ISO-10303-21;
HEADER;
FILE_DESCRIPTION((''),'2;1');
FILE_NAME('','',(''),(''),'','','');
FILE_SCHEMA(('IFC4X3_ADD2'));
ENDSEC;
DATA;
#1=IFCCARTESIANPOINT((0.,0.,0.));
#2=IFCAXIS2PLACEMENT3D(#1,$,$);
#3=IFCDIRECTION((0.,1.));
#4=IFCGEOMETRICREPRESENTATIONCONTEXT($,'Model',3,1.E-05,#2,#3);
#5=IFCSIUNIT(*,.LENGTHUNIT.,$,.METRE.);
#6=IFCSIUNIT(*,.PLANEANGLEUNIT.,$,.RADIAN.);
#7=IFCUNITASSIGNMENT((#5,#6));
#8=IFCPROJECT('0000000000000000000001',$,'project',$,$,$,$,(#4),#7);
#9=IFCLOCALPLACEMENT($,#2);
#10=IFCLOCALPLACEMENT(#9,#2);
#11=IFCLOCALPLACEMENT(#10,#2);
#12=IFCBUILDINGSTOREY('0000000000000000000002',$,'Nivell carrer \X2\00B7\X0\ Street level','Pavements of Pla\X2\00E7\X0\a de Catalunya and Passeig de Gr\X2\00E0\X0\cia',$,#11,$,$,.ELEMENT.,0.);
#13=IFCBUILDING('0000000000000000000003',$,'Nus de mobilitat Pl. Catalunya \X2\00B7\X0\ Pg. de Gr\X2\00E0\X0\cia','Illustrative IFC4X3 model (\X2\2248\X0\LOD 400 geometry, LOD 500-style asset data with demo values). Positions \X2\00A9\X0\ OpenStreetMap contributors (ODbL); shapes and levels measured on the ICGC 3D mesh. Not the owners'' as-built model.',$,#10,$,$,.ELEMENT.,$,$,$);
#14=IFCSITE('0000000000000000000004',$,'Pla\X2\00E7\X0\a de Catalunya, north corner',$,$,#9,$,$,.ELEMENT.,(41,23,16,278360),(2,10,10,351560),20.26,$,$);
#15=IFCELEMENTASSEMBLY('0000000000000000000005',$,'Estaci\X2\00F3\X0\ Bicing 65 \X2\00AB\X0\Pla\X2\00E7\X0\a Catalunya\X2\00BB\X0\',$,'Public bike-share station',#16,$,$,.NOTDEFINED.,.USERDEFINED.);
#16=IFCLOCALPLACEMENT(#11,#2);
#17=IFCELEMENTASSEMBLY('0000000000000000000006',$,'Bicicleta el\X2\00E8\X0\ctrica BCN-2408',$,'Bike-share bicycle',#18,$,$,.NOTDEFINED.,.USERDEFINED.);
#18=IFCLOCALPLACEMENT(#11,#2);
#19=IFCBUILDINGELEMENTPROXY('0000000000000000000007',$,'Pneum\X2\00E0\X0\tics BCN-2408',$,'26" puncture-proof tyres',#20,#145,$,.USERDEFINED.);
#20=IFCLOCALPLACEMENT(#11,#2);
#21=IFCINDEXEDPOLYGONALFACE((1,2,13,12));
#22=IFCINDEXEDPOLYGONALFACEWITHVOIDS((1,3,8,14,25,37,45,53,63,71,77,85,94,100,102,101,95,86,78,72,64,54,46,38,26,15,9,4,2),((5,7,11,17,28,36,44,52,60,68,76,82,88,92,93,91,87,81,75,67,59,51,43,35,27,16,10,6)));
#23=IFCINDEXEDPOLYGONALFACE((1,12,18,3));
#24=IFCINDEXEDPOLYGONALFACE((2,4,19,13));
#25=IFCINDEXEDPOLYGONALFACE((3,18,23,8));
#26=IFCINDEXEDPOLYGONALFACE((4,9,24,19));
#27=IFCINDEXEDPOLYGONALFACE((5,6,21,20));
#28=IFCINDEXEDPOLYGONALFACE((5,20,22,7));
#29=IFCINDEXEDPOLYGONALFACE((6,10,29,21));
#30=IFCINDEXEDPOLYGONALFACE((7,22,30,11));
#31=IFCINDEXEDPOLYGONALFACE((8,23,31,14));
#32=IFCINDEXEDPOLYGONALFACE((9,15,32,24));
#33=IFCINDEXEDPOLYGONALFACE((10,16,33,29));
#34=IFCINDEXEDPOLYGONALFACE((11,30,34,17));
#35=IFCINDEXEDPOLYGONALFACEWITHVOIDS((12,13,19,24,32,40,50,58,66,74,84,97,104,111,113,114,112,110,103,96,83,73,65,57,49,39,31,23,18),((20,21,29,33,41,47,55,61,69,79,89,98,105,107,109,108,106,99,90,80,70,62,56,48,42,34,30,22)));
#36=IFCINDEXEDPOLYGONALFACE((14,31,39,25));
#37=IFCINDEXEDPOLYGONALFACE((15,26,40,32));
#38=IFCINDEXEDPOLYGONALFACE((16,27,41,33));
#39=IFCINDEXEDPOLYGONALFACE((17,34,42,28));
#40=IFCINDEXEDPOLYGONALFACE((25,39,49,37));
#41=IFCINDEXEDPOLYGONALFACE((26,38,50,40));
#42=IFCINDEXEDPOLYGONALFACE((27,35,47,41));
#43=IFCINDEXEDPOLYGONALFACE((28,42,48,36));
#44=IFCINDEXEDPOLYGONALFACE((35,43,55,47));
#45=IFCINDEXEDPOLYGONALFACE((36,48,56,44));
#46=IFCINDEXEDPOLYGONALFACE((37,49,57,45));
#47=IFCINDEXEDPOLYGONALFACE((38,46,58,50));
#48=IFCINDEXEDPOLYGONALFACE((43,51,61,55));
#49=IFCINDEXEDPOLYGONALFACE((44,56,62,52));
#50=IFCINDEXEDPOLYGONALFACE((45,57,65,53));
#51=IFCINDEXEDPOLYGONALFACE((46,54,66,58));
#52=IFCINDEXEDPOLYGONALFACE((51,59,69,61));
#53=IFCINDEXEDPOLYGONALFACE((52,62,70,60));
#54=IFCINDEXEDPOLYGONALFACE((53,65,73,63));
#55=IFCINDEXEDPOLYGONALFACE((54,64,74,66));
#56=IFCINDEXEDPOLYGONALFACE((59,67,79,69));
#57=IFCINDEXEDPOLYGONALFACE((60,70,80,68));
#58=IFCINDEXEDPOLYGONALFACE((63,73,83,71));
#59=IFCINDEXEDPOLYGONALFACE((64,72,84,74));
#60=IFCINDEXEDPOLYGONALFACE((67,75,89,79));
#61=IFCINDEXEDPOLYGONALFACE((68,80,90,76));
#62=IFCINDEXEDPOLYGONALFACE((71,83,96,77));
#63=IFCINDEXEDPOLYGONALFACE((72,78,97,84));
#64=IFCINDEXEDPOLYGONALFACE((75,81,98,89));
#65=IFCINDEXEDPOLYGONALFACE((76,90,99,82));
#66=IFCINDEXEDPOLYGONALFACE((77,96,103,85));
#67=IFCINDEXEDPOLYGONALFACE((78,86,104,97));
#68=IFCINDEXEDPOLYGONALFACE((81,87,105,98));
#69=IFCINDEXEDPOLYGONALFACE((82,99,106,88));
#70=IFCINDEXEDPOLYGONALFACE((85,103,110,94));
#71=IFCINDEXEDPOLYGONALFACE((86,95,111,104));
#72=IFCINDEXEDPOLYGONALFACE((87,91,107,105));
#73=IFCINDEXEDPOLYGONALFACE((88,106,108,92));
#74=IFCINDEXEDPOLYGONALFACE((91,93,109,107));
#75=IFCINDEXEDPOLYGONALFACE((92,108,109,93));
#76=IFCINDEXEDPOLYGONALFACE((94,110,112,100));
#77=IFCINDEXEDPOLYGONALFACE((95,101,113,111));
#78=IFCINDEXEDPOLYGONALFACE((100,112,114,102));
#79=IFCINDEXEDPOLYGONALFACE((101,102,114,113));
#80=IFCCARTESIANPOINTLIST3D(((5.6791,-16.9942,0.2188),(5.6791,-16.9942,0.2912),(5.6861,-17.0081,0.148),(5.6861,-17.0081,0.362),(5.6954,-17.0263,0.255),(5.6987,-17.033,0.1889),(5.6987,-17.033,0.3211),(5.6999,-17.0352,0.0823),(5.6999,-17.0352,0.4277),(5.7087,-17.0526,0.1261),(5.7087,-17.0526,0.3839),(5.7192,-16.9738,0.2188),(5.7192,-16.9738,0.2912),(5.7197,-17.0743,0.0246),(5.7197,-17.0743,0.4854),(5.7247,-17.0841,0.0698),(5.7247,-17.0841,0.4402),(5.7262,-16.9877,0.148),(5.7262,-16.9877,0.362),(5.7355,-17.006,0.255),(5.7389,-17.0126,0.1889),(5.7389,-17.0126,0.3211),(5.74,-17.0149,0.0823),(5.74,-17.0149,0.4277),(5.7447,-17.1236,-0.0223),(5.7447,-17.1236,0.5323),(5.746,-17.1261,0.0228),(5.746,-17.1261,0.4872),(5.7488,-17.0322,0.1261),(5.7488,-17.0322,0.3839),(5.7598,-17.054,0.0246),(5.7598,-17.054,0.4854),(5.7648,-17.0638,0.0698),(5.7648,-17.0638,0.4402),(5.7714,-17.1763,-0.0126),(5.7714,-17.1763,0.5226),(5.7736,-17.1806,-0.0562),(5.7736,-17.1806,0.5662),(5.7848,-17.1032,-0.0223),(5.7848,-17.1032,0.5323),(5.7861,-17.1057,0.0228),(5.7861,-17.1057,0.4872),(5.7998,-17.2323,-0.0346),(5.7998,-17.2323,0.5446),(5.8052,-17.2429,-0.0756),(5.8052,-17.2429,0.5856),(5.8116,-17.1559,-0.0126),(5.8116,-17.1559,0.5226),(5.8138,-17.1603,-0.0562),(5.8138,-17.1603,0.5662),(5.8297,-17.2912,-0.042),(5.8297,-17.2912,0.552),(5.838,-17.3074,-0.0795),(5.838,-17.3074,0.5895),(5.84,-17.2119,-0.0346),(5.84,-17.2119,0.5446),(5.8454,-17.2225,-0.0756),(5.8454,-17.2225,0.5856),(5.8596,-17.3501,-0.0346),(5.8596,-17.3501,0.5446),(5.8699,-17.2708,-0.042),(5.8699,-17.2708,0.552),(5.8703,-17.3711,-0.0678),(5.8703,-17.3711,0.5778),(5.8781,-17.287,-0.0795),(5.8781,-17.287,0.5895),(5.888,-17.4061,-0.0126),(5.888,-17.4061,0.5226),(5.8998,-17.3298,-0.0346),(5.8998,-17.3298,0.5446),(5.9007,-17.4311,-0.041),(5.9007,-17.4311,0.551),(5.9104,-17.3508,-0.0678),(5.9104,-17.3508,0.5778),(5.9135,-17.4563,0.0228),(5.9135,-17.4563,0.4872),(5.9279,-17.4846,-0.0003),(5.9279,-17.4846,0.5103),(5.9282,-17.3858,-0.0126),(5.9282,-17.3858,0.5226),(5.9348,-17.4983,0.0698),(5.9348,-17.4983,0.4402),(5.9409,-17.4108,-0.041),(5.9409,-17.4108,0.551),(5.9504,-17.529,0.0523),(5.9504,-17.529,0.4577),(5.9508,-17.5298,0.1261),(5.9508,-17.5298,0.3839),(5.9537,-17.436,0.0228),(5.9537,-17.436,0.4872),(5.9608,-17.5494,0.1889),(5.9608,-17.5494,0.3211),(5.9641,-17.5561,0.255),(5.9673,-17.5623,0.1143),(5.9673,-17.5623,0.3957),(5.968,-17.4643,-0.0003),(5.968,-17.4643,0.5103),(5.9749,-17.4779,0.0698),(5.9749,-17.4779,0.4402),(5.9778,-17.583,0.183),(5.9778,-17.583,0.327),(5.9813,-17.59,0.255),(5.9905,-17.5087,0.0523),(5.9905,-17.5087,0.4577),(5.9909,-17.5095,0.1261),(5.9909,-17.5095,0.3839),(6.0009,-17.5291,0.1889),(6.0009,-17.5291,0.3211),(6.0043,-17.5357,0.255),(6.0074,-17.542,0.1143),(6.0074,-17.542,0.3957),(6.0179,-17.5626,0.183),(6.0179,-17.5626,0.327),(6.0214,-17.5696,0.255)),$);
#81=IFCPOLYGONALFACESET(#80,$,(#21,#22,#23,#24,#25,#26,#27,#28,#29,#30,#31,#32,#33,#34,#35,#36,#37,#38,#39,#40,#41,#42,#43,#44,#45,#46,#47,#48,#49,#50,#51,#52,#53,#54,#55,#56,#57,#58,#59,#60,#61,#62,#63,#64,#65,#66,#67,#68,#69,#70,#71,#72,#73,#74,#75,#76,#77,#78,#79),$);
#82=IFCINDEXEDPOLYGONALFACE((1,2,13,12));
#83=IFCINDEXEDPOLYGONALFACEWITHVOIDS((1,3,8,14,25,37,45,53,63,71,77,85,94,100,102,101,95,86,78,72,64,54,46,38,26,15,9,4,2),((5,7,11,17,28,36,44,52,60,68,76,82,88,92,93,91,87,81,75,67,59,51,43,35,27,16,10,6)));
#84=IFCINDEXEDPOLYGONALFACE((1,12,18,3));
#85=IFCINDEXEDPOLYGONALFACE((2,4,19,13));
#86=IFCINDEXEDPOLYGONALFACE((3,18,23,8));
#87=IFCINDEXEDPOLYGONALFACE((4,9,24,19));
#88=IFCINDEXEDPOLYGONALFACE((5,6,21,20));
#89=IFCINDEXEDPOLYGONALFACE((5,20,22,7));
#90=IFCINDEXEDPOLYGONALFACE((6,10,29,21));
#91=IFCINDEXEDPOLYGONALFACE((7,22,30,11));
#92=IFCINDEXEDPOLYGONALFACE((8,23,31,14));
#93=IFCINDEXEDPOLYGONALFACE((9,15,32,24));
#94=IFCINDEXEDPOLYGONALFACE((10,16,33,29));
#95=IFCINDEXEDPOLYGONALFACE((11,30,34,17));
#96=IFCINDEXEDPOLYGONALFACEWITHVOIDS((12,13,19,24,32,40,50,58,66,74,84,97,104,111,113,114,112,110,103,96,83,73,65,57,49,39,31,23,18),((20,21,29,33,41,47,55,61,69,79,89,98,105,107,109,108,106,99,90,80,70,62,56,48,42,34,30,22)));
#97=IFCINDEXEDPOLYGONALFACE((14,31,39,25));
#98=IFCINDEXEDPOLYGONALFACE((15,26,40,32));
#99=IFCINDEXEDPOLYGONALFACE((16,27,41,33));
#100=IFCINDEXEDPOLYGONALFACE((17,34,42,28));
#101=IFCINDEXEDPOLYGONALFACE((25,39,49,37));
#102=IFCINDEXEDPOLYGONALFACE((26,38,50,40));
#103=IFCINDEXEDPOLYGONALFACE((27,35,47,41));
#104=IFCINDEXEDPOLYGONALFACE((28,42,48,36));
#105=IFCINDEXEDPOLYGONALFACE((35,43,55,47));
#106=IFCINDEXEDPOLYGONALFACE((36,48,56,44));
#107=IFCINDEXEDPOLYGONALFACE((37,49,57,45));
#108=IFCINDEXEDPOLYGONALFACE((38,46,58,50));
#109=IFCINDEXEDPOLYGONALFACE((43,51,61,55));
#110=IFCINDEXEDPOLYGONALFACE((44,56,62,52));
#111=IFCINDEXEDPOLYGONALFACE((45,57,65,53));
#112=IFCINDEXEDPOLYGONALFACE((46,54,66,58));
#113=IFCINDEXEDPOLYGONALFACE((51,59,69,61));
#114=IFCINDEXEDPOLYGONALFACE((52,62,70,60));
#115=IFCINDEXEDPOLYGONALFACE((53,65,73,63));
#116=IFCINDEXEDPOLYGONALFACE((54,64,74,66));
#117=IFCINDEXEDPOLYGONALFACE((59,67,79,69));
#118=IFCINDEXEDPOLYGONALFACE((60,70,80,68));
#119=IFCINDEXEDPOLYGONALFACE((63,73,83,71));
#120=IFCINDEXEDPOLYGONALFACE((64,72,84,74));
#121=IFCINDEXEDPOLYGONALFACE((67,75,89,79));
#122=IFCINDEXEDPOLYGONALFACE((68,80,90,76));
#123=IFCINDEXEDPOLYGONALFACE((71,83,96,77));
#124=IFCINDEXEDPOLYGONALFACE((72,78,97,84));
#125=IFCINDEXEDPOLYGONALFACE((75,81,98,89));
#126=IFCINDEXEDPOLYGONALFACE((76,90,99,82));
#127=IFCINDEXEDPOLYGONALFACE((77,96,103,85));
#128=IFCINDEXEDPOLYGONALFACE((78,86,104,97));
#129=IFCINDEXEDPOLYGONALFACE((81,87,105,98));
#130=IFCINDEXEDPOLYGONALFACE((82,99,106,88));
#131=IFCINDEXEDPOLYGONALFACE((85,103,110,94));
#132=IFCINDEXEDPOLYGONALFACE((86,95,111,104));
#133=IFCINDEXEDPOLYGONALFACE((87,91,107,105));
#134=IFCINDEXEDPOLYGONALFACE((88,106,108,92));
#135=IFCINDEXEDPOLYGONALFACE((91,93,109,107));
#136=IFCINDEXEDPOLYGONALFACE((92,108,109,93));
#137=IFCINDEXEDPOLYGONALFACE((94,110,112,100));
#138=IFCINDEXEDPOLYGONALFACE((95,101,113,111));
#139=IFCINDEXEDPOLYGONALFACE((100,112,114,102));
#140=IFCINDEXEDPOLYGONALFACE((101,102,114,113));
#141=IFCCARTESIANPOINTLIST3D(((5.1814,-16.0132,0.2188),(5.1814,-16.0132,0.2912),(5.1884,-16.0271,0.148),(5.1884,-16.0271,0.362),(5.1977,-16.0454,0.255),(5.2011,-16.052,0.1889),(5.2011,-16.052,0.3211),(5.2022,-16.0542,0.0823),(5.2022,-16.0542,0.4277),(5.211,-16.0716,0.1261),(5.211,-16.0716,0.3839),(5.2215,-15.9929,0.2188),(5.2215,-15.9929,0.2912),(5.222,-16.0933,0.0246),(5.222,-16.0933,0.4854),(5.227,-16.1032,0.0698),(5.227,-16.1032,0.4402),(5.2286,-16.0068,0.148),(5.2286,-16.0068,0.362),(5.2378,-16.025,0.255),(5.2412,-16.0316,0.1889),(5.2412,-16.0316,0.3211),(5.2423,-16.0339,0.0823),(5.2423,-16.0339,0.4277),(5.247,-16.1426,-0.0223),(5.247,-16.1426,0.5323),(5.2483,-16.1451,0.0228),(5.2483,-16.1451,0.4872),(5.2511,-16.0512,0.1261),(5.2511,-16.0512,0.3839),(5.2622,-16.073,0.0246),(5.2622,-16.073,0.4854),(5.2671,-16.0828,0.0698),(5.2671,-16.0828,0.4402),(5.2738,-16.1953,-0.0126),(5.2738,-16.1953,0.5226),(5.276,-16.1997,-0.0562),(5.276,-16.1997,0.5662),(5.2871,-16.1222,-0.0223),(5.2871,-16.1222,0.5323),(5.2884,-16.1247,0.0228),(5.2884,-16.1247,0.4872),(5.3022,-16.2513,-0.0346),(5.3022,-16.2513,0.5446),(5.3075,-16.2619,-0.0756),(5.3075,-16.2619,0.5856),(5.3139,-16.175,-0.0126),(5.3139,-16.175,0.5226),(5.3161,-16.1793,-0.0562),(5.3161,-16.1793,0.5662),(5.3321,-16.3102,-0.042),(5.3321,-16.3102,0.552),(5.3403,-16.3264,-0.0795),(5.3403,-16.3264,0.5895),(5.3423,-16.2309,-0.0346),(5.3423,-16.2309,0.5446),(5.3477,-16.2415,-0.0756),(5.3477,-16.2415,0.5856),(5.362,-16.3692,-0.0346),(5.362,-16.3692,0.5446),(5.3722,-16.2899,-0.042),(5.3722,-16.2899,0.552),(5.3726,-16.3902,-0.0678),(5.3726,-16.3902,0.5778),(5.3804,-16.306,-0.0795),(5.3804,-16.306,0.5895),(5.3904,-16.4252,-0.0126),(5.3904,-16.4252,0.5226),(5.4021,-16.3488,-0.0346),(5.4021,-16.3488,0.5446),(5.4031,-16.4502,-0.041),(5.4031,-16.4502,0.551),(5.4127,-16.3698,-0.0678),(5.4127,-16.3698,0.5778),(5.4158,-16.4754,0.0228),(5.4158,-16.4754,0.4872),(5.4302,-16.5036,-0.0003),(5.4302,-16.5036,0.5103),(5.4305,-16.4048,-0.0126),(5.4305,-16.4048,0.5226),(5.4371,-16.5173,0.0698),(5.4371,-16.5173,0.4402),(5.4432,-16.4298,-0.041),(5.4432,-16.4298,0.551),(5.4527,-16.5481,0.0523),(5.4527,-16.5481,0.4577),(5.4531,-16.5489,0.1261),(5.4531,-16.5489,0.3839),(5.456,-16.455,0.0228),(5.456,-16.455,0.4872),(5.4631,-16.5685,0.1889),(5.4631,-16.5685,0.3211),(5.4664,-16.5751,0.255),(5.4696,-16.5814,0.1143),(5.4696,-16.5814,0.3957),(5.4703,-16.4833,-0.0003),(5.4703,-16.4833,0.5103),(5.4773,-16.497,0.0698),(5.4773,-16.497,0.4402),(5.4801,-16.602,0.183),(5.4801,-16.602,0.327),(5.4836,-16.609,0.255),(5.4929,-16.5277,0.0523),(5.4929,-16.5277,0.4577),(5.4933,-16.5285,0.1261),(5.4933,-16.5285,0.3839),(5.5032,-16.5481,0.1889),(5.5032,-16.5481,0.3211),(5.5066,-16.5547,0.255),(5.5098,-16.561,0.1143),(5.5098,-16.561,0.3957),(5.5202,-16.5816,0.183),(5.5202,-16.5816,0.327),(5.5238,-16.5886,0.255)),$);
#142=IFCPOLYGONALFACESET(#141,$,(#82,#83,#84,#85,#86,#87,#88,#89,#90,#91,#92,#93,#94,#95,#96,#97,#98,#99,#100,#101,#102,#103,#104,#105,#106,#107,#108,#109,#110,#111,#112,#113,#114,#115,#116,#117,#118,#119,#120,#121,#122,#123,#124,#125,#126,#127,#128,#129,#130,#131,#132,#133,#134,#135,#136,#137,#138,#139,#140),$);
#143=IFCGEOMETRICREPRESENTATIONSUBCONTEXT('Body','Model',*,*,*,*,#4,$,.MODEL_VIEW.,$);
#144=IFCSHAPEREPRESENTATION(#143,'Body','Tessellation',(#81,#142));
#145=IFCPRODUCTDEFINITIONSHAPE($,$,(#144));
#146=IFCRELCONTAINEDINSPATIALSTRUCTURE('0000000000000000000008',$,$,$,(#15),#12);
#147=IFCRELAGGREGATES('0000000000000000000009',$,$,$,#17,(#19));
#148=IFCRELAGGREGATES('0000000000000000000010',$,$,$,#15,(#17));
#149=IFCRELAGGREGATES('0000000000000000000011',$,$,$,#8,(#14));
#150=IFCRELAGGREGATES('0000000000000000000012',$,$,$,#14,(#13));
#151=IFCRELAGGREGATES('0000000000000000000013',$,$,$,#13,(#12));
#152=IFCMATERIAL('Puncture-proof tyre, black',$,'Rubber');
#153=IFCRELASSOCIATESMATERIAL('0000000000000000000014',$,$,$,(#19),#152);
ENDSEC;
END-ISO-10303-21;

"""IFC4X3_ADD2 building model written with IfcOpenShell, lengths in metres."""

from ifc_helpers import new_model, si_unit, direction, frame, origin, origin_2d_with_axis, place, context, subcontext, project, spatial, hollow_circle, extrude, material, element, aggregate, save


model = new_model("IFC4X3_ADD2")

# Units and contexts
model_context = context("Model", 3, precision=1e-05, world=origin(), true_north=direction((0.0, 1.0)))
body_context = subcontext(model_context, "Body", "Model", "MODEL_VIEW")
ifc_project = project(units=[si_unit("LENGTHUNIT", "METRE"), si_unit("PLANEANGLEUNIT", "RADIAN")], contexts=[model_context])

# Site, building, storey
site_placement = place(None, origin())
site = spatial("IfcSite", under=ifc_project, at=site_placement, Name="Plaça de Catalunya, north corner", CompositionType="ELEMENT", RefLatitude=(41, 23, 16, 278360), RefLongitude=(2, 10, 10, 351560), RefElevation=20.26)
building_placement = place(site_placement, origin())
building = spatial("IfcBuilding", under=site, at=building_placement, Name="Nus de mobilitat Pl. Catalunya · Pg. de Gràcia", Description="Illustrative IFC4X3 model (≈LOD 400 geometry, LOD 500-style asset data with demo values). Positions © OpenStreetMap contributors (ODbL); shapes and levels measured on the ICGC 3D mesh. Not the owners' as-built model.", CompositionType="ELEMENT")
storey_placement = place(building_placement, origin())
storey = spatial("IfcBuildingStorey", under=building, at=storey_placement, Name="Nivell carrer · Street level", Description="Pavements of Plaça de Catalunya and Passeig de Gràcia", CompositionType="ELEMENT", Elevation=0.0)

# Element assemblies, building element proxy
assembly_1_placement = place(building_placement, origin())
assembly_1 = element("IfcElementAssembly", 1, at=assembly_1_placement, inside=storey, Name="Estació Bicing 65 «Plaça Catalunya»", ObjectType="Public bike-share station", AssemblyPlace="NOTDEFINED", PredefinedType="USERDEFINED")
assembly_2_placement = place(building_placement, origin())
assembly_2 = element("IfcElementAssembly", 2, at=assembly_2_placement, Name="Bicicleta elèctrica BCN-2408", ObjectType="Bike-share bicycle", AssemblyPlace="NOTDEFINED", PredefinedType="USERDEFINED")
ifc_material_1 = material(Name="Puncture-proof tyre, black", Category="Rubber")
proxy_1_placement = place(building_placement, origin())
proxy_1 = element("IfcBuildingElementProxy", 3, at=proxy_1_placement, material=ifc_material_1, Name="Pneumàtics BCN-2408", ObjectType="26\" puncture-proof tyres", PredefinedType="USERDEFINED", context=body_context, shape_type="SweptSolid", body=[
    extrude(hollow_circle(Radius=0.335, WallThickness=0.038, at=origin_2d_with_axis()), frame((5.8297, -17.2912, 0.255), z_axis=(0.891798, 0.452435, 0.0), x_axis=(0.452435, -0.891798, 0.0)), (0.0, 0.0, 1.0), 0.045),
    extrude(hollow_circle(Radius=0.335, WallThickness=0.038, at=origin_2d_with_axis()), frame((5.3321, -16.3102, 0.255), z_axis=(0.891798, 0.452435, 0.0), x_axis=(0.452435, -0.891798, 0.0)), (0.0, 0.0, 1.0), 0.045),
])
aggregate(assembly_2, [proxy_1])
aggregate(assembly_1, [assembly_2])

save(model, "model.ifc")
